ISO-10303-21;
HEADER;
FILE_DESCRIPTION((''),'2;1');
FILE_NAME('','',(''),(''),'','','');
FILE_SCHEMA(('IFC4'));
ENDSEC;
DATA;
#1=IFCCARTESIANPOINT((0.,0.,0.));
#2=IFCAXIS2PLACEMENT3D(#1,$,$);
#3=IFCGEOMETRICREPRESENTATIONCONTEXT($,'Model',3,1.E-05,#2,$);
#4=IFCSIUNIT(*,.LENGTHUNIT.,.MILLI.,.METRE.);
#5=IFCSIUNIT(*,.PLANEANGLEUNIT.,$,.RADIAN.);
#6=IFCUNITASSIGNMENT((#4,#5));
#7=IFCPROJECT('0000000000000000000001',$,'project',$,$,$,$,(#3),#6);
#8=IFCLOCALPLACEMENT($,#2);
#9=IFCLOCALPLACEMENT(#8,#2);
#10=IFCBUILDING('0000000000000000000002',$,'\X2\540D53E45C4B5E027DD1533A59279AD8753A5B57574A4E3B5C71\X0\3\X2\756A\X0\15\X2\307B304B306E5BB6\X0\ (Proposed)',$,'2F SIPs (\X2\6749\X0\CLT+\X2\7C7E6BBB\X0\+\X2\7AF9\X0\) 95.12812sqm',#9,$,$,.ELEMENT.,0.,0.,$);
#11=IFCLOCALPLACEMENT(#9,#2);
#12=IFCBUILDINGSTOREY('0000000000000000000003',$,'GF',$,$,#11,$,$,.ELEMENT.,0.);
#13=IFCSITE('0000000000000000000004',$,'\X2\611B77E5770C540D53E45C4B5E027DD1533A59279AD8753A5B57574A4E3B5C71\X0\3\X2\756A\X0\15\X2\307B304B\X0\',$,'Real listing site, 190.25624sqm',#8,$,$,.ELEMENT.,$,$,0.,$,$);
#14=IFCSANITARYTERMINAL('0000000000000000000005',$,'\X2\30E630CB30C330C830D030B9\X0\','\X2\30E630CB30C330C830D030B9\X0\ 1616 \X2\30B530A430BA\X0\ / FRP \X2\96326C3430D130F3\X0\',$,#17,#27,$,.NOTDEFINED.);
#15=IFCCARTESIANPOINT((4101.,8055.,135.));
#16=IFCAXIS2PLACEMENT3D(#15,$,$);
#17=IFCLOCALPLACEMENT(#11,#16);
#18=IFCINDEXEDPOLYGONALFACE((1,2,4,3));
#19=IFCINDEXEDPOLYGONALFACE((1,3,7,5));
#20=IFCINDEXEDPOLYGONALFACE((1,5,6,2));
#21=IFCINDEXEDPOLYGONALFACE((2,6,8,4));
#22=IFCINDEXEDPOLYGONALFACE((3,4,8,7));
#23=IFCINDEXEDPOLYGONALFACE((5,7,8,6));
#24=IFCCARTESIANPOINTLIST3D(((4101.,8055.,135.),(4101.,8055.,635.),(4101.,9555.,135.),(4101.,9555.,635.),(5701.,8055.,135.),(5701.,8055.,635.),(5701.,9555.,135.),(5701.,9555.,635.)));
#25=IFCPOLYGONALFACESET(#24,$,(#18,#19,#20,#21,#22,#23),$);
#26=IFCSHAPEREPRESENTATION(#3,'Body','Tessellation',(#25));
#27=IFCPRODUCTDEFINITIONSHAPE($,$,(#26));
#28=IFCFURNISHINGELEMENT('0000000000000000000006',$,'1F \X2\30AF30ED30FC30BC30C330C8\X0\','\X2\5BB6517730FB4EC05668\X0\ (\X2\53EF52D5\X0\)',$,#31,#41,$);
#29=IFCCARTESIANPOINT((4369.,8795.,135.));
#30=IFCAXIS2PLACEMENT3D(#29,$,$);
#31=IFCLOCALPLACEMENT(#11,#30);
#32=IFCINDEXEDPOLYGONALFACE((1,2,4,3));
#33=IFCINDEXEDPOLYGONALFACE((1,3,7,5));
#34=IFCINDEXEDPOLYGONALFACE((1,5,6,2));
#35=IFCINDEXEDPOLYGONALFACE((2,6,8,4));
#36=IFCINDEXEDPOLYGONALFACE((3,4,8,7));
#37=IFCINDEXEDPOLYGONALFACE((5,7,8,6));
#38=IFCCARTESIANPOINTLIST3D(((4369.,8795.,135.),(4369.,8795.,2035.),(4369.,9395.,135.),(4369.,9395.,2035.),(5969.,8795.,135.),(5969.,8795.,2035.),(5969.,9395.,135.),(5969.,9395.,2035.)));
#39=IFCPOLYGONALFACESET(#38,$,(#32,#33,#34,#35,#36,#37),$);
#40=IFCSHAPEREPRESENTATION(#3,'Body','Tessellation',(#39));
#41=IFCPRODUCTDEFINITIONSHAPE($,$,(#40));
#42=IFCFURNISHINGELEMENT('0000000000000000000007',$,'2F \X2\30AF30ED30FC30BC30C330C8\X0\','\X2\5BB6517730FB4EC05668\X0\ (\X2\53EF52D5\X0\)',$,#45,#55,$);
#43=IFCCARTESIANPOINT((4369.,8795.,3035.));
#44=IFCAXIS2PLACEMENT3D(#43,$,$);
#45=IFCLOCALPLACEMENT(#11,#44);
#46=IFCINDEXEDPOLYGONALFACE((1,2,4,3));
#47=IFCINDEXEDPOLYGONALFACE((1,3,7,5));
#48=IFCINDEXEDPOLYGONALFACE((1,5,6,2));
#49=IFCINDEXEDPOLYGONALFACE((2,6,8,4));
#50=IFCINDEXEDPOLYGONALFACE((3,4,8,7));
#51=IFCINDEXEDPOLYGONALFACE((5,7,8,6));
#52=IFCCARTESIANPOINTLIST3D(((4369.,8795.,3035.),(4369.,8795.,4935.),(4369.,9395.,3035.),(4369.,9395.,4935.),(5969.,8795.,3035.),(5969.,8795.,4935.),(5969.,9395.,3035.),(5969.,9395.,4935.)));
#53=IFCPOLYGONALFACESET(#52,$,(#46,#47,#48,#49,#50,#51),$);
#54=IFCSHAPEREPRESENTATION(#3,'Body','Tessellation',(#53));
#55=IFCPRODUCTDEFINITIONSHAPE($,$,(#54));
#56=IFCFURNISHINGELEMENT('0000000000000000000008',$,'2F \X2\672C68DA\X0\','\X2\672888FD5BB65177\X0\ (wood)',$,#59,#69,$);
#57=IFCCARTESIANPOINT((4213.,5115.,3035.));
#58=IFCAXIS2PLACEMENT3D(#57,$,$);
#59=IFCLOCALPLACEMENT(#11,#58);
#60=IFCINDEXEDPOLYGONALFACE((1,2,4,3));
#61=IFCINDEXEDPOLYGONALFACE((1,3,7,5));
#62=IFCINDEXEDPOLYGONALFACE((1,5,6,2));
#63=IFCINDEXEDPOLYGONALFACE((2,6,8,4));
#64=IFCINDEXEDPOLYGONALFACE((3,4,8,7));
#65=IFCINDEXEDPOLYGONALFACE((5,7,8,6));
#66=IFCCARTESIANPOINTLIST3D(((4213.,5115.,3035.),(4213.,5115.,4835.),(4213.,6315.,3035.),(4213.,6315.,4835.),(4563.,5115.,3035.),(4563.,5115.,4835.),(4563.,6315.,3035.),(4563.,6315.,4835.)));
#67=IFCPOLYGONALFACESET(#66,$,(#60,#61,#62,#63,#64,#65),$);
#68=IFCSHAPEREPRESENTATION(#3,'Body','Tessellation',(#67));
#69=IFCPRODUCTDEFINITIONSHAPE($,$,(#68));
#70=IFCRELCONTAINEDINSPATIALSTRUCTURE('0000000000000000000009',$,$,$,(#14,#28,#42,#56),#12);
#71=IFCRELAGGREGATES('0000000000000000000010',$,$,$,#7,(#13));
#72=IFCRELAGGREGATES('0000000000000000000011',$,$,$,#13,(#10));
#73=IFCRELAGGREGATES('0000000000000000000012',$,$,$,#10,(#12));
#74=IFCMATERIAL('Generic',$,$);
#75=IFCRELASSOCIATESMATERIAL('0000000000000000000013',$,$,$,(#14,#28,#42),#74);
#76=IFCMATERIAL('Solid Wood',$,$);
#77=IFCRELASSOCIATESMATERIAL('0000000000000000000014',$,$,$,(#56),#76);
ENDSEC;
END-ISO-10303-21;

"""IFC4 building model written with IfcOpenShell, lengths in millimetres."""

from ifc_helpers import new_model, si_unit, frame, frame_2d, origin, place, context, project, spatial, rectangle, extrude, material, element, save


model = new_model("IFC4")

# Units and contexts
model_context = context("Model", 3, precision=1e-05, world=origin())
ifc_project = project(units=[si_unit("LENGTHUNIT", "METRE", prefix="MILLI"), si_unit("PLANEANGLEUNIT", "RADIAN")], contexts=[model_context])

# Site, building, storey
site_placement = place(None, origin())
site = spatial("IfcSite", under=ifc_project, at=site_placement, Name="愛知県名古屋市緑区大高町字坊主山3番15ほか", ObjectType="Real listing site, 190.25624sqm", CompositionType="ELEMENT", RefElevation=0.0)
building_placement = place(site_placement, origin())
building = spatial("IfcBuilding", under=site, at=building_placement, Name="名古屋市緑区大高町字坊主山3番15ほかの家 (Proposed)", ObjectType="2F SIPs (杉CLT+籾殻+竹) 95.12812sqm", CompositionType="ELEMENT", ElevationOfRefHeight=0.0, ElevationOfTerrain=0.0)
storey_placement = place(building_placement, origin())
storey = spatial("IfcBuildingStorey", under=building, at=storey_placement, Name="GF", CompositionType="ELEMENT", Elevation=0.0)

# Shared definitions
ifc_material_1 = material(Name="Solid Wood")

# Shared definitions
ifc_material_2 = material(Name="Generic")

# Sanitary terminal
sanitary_terminal_placement = place(storey_placement, frame((4101.0, 8055.0, 135.0)))
element("IfcSanitaryTerminal", 1, at=sanitary_terminal_placement, inside=storey, material=ifc_material_2, Name="ユニットバス", Description="ユニットバス 1616 サイズ / FRP 防水パン", PredefinedType="NOTDEFINED", context=model_context, shape_type="SweptSolid", body=[
    extrude(rectangle(XDim=1600.0, YDim=1500.0, at=frame_2d((800.0, 750.0))), frame((4101.0, 8055.0, 135.0)), (0.0, 0.0, 1.0), 500.0),
])

# Furnishing elements
furnishing_1_placement = place(storey_placement, frame((4369.0, 8795.0, 135.0)))
element("IfcFurnishingElement", 2, at=furnishing_1_placement, inside=storey, material=ifc_material_2, Name="1F クローゼット", Description="家具・什器 (可動)", context=model_context, shape_type="SweptSolid", body=[
    extrude(rectangle(XDim=1600.0, YDim=600.0, at=frame_2d((800.0, 300.0))), frame((4369.0, 8795.0, 135.0)), (0.0, 0.0, 1.0), 1900.0),
])
furnishing_2_placement = place(storey_placement, frame((4369.0, 8795.0, 3035.0)))
element("IfcFurnishingElement", 3, at=furnishing_2_placement, inside=storey, material=ifc_material_2, Name="2F クローゼット", Description="家具・什器 (可動)", context=model_context, shape_type="SweptSolid", body=[
    extrude(rectangle(XDim=1600.0, YDim=600.0, at=frame_2d((800.0, 300.0))), frame((4369.0, 8795.0, 3035.0)), (0.0, 0.0, 1.0), 1900.0),
])
furnishing_3_placement = place(storey_placement, frame((4213.0, 5115.0, 3035.0)))
element("IfcFurnishingElement", 4, at=furnishing_3_placement, inside=storey, material=ifc_material_1, Name="2F 本棚", Description="木製家具 (wood)", context=model_context, shape_type="SweptSolid", body=[
    extrude(rectangle(XDim=350.0, YDim=1200.0, at=frame_2d((175.0, 600.0))), frame((4213.0, 5115.0, 3035.0)), (0.0, 0.0, 1.0), 1800.0),
])

save(model, "model.ifc")
